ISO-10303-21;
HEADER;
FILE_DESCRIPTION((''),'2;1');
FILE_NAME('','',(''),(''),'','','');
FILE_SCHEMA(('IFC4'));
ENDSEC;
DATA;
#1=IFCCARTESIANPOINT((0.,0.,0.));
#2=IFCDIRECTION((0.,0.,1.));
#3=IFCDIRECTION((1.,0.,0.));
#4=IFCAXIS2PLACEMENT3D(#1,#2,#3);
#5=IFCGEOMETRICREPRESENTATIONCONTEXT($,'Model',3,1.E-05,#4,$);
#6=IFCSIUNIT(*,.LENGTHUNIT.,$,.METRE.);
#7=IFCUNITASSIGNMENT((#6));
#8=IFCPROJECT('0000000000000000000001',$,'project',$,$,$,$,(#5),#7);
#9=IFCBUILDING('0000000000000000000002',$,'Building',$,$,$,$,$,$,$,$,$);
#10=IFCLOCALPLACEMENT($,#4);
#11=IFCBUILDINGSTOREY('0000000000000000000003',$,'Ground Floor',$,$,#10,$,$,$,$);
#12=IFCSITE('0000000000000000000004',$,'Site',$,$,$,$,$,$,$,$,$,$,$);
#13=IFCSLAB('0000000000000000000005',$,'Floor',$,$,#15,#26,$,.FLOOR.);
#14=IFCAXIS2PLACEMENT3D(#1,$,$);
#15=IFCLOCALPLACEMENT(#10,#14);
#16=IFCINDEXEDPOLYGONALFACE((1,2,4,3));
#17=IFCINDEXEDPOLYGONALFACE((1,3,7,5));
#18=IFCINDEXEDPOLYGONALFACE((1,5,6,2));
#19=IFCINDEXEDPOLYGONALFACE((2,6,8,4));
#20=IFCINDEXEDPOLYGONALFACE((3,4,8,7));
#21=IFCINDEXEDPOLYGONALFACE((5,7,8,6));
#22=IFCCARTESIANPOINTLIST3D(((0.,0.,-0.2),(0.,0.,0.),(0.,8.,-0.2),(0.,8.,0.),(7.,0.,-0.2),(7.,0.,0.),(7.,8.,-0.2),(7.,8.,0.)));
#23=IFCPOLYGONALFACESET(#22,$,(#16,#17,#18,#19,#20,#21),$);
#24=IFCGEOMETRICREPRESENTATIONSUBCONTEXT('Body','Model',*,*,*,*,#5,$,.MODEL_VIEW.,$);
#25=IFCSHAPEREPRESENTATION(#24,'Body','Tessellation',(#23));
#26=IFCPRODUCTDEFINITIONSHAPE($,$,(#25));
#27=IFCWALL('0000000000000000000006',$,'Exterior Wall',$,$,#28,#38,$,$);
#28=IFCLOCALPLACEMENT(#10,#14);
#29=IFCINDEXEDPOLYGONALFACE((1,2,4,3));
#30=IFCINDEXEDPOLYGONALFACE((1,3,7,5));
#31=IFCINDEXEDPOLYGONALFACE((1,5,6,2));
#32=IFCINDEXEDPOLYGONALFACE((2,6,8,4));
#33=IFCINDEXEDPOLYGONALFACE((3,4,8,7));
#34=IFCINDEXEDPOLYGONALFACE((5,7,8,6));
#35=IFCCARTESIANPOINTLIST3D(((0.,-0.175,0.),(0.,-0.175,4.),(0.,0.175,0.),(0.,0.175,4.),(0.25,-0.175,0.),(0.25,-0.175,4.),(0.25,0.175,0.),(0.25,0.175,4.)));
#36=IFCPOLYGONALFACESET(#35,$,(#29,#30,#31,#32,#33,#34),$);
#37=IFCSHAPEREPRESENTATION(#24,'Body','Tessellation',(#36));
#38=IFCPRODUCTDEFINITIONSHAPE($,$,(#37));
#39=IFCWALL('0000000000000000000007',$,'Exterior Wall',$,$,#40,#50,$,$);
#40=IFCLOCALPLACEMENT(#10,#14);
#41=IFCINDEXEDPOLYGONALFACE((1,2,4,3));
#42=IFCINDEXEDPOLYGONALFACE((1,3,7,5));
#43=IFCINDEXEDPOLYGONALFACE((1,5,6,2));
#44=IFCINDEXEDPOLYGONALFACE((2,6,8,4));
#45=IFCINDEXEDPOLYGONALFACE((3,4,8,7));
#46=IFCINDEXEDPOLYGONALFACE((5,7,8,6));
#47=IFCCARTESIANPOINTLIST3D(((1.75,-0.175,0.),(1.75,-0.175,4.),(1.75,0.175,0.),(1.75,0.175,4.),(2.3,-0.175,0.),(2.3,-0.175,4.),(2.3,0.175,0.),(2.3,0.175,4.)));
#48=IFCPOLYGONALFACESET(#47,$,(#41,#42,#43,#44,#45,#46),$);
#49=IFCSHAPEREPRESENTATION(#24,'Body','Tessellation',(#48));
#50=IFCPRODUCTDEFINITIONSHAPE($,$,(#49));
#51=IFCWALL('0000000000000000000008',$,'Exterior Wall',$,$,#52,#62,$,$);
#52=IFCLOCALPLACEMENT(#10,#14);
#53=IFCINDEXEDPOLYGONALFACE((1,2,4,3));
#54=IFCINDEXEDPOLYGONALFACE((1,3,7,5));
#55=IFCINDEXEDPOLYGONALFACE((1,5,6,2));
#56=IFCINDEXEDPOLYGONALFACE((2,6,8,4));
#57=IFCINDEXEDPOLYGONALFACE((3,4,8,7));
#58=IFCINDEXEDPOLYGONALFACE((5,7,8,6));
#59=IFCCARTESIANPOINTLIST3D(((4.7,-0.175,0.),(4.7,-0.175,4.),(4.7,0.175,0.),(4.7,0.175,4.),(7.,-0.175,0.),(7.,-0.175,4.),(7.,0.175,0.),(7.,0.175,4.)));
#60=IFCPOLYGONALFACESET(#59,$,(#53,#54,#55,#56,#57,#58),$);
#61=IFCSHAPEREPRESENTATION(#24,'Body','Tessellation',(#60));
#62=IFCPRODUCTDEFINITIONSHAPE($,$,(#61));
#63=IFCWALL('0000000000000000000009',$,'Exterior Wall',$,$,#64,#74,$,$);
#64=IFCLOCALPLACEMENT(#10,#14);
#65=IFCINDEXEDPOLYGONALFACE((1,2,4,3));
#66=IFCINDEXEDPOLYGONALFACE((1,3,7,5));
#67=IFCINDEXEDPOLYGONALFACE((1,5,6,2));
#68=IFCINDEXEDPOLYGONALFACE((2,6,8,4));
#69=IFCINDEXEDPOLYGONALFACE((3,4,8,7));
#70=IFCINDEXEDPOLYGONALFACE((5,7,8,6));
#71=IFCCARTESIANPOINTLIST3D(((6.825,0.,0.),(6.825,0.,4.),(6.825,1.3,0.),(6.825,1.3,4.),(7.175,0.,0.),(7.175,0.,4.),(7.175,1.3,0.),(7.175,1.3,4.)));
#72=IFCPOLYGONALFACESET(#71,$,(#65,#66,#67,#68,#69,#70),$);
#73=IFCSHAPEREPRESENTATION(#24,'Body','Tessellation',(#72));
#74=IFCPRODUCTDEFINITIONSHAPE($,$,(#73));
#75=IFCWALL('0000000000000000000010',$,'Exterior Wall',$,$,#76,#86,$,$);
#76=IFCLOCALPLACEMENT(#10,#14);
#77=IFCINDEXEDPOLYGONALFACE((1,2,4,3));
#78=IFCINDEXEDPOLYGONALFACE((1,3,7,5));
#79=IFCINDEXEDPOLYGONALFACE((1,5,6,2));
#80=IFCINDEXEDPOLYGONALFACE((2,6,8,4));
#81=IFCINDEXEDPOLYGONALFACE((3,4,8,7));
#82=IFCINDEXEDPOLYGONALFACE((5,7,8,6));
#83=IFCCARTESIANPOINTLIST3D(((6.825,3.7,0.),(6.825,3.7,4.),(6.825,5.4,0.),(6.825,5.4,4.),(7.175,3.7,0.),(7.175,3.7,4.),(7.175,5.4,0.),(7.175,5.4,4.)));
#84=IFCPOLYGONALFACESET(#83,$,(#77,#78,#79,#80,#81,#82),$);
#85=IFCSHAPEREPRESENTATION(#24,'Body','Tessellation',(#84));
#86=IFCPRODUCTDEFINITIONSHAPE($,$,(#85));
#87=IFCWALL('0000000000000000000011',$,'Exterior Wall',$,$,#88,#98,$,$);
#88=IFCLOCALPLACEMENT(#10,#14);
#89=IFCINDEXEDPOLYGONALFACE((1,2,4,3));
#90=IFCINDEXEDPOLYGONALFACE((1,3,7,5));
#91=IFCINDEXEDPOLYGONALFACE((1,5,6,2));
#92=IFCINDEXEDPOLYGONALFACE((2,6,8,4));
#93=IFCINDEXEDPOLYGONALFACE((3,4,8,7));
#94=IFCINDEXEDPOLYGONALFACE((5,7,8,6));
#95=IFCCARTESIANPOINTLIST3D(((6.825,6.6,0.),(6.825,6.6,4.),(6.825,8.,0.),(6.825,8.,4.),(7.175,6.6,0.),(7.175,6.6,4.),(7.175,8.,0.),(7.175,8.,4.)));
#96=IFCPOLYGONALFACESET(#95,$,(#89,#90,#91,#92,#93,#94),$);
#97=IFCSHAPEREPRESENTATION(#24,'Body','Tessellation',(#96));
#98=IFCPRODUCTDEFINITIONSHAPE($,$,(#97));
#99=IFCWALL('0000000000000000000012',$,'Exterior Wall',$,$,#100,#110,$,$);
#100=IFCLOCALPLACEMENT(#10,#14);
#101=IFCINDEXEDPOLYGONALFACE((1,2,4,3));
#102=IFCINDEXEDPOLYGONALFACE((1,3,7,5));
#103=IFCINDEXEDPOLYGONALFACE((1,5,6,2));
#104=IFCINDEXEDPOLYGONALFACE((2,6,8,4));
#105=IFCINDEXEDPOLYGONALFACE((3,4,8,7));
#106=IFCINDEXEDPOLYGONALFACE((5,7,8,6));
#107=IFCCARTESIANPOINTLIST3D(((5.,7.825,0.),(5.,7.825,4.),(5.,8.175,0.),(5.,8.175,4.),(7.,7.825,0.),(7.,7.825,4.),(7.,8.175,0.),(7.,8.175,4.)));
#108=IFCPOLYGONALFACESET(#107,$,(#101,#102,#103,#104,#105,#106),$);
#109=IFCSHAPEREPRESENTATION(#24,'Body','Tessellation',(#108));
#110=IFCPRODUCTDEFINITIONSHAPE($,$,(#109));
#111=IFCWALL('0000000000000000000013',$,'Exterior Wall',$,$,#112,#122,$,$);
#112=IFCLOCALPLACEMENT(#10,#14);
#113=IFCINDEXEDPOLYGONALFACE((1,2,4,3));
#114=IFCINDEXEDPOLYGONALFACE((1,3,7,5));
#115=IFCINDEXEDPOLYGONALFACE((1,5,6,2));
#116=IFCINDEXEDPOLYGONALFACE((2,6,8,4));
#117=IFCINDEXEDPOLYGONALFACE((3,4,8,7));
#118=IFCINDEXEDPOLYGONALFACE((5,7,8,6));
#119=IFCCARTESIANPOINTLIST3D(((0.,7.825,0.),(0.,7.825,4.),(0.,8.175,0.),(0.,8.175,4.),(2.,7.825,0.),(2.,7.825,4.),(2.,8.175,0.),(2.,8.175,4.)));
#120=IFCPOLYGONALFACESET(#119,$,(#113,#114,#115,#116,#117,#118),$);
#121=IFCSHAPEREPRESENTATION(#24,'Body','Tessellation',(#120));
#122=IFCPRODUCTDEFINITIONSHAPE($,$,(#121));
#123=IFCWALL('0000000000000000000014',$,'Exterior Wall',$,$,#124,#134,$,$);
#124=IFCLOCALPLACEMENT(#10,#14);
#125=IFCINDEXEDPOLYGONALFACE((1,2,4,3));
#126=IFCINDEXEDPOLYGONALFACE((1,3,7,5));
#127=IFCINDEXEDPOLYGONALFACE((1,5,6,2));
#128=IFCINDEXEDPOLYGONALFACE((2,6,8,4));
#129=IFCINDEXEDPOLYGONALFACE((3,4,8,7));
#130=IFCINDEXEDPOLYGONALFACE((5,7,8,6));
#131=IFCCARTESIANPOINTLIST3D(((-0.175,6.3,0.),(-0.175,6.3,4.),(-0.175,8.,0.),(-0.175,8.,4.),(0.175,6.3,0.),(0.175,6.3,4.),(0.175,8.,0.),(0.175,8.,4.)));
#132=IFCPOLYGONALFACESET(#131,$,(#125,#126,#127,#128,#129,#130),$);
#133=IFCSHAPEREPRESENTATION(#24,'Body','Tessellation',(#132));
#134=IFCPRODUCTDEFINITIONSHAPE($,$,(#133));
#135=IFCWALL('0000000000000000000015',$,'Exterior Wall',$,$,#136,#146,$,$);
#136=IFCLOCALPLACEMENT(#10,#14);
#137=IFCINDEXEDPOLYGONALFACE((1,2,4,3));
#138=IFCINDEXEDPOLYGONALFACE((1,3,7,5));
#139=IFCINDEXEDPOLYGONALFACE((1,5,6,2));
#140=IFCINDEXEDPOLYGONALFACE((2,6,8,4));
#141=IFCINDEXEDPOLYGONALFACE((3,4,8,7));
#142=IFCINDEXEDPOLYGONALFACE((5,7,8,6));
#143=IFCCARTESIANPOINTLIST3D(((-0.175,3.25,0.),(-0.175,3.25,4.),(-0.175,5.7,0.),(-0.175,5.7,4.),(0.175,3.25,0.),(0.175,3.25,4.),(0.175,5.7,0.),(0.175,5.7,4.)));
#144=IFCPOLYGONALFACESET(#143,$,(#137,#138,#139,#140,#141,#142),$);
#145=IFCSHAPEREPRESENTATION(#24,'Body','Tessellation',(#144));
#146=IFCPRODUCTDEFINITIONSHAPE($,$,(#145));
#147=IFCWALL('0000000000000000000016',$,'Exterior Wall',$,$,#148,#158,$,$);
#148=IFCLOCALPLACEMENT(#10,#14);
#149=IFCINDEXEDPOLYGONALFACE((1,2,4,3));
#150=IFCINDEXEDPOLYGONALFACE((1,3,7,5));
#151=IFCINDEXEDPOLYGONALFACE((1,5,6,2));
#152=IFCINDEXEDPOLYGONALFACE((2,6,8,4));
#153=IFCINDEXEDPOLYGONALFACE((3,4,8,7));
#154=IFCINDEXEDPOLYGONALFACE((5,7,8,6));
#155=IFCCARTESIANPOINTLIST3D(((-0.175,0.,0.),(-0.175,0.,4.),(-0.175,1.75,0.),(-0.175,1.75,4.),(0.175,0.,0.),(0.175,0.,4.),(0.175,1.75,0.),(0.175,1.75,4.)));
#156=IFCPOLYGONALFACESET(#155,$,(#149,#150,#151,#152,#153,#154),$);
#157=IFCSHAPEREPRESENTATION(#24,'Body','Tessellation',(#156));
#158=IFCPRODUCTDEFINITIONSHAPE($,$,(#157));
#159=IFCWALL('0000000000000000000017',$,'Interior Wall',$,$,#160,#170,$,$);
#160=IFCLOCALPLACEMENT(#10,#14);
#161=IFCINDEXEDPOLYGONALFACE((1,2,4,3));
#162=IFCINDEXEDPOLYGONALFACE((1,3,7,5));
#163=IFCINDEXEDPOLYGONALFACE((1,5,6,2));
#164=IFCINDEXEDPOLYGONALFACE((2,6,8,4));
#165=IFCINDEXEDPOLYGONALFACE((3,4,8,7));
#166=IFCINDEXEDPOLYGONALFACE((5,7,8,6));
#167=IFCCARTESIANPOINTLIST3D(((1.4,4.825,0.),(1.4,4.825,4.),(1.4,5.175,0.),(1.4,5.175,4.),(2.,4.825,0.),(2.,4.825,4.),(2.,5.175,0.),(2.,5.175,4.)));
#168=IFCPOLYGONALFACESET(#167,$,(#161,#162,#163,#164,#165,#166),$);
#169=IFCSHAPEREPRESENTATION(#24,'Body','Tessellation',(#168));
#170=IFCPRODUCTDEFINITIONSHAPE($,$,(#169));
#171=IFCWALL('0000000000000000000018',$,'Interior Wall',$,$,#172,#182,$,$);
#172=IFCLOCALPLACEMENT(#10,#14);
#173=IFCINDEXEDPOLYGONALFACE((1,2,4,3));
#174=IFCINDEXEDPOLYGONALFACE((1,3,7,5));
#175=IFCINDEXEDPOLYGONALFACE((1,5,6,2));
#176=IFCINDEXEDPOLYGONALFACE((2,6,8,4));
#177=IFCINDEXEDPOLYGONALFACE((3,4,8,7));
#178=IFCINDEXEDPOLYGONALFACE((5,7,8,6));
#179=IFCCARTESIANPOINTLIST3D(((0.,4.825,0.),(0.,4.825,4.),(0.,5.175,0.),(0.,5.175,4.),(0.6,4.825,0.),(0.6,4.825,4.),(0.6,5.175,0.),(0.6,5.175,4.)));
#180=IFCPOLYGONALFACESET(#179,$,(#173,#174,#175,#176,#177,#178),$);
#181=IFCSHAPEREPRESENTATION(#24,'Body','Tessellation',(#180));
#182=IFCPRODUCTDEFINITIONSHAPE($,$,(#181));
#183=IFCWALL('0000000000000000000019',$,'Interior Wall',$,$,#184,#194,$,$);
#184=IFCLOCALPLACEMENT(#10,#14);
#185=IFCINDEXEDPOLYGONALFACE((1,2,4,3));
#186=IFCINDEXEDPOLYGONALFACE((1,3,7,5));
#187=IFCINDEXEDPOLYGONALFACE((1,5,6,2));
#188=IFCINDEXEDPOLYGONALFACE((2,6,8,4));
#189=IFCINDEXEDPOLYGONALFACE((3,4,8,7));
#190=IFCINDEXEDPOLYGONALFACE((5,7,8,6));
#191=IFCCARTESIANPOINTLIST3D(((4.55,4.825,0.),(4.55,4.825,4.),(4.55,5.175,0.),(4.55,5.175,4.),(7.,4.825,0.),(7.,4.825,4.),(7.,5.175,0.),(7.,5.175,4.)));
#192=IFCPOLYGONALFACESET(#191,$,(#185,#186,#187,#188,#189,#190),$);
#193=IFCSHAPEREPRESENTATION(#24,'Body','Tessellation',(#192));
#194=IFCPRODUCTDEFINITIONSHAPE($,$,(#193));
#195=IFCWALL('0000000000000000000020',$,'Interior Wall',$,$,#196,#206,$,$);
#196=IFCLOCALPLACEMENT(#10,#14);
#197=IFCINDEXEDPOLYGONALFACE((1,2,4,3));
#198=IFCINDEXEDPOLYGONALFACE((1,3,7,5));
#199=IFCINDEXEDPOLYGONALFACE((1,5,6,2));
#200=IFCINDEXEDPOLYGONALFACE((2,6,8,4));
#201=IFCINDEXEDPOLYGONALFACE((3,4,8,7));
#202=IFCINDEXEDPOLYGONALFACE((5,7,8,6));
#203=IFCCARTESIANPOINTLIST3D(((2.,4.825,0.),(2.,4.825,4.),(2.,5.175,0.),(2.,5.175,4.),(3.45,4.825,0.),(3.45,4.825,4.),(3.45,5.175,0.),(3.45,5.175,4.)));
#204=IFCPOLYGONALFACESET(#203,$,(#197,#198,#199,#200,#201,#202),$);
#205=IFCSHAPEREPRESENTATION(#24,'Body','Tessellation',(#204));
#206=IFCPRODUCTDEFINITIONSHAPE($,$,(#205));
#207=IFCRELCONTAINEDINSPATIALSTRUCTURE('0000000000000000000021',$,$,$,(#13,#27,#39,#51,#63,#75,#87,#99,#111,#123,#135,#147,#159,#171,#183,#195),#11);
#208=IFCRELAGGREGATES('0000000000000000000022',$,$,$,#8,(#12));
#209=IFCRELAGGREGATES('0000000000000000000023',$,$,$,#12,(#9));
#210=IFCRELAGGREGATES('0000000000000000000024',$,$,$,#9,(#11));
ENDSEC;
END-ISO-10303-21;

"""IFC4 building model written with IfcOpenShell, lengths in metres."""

from ifc_helpers import new_model, si_unit, frame, origin_with_axes, place, context, subcontext, project, spatial, indexed_curve, outline, extrude, element, save


model = new_model("IFC4")

# Units and contexts
model_context = context("Model", 3, precision=1e-05, world=origin_with_axes())
body_context = subcontext(model_context, "Body", "Model", "MODEL_VIEW")
ifc_project = project(units=[si_unit("LENGTHUNIT", "METRE")], contexts=[model_context])

# Site, building, storey
site = spatial("IfcSite", under=ifc_project, Name="Site")
building = spatial("IfcBuilding", under=site, Name="Building")
storey_placement = place(None, origin_with_axes())
storey = spatial("IfcBuildingStorey", under=building, at=storey_placement, Name="Ground Floor")

# Slab
slab_placement = place(storey_placement, frame((0.0, 0.0, -0.2), z_axis=(0.0, 0.0, 1.0), x_axis=(1.0, 0.0, 0.0)))
element("IfcSlab", 1, at=slab_placement, inside=storey, Name="Floor", PredefinedType="FLOOR", context=body_context, shape_type="SweptSolid", body=[
    extrude(outline(indexed_curve([(0.0, 0.0), (7.0, 0.0), (7.0, 8.0), (0.0, 8.0)])), None, (0.0, 0.0, 1.0), 0.2),
])

# Walls
wall_1_placement = place(storey_placement, origin_with_axes())
element("IfcWall", 2, at=wall_1_placement, inside=storey, Name="Exterior Wall", context=body_context, shape_type="SweptSolid", body=[
    extrude(outline(indexed_curve([(0.0, 0.0), (0.0, 0.35), (0.25, 0.35), (0.25, 0.0), (0.0, 0.0)], self_intersect=False)), frame((0.0, -0.175, 0.0), z_axis=(0.0, 0.0, 1.0), x_axis=(1.0, 0.0, 0.0)), (0.0, 0.0, 1.0), 4.0),
])
wall_2_placement = place(storey_placement, frame((1.75, 0.0, 0.0), z_axis=(0.0, 0.0, 1.0), x_axis=(1.0, 0.0, 0.0)))
element("IfcWall", 3, at=wall_2_placement, inside=storey, Name="Exterior Wall", context=body_context, shape_type="SweptSolid", body=[
    extrude(outline(indexed_curve([(0.0, 0.0), (0.0, 0.35), (0.55, 0.35), (0.55, 0.0), (0.0, 0.0)], self_intersect=False)), frame((0.0, -0.175, 0.0), z_axis=(0.0, 0.0, 1.0), x_axis=(1.0, 0.0, 0.0)), (0.0, 0.0, 1.0), 4.0),
])
wall_3_placement = place(storey_placement, frame((4.7, 0.0, 0.0), z_axis=(0.0, 0.0, 1.0), x_axis=(1.0, 0.0, 0.0)))
element("IfcWall", 4, at=wall_3_placement, inside=storey, Name="Exterior Wall", context=body_context, shape_type="SweptSolid", body=[
    extrude(outline(indexed_curve([(0.0, 0.0), (0.0, 0.35), (2.3, 0.35), (2.3, 0.0), (0.0, 0.0)], self_intersect=False)), frame((0.0, -0.175, 0.0), z_axis=(0.0, 0.0, 1.0), x_axis=(1.0, 0.0, 0.0)), (0.0, 0.0, 1.0), 4.0),
])
wall_4_placement = place(storey_placement, frame((7.0, 0.0, 0.0), z_axis=(0.0, 0.0, 1.0), x_axis=(0.0, 1.0, 0.0)))
element("IfcWall", 5, at=wall_4_placement, inside=storey, Name="Exterior Wall", context=body_context, shape_type="SweptSolid", body=[
    extrude(outline(indexed_curve([(0.0, 0.0), (0.0, 0.35), (1.3, 0.35), (1.3, 0.0), (0.0, 0.0)], self_intersect=False)), frame((0.0, -0.175, 0.0), z_axis=(0.0, 0.0, 1.0), x_axis=(1.0, 0.0, 0.0)), (0.0, 0.0, 1.0), 4.0),
])
wall_5_placement = place(storey_placement, frame((7.0, 3.7, 0.0), z_axis=(0.0, 0.0, 1.0), x_axis=(0.0, 1.0, 0.0)))
element("IfcWall", 6, at=wall_5_placement, inside=storey, Name="Exterior Wall", context=body_context, shape_type="SweptSolid", body=[
    extrude(outline(indexed_curve([(0.0, 0.0), (0.0, 0.35), (1.7, 0.35), (1.7, 0.0), (0.0, 0.0)], self_intersect=False)), frame((0.0, -0.175, 0.0), z_axis=(0.0, 0.0, 1.0), x_axis=(1.0, 0.0, 0.0)), (0.0, 0.0, 1.0), 4.0),
])
wall_6_placement = place(storey_placement, frame((7.0, 6.6, 0.0), z_axis=(0.0, 0.0, 1.0), x_axis=(0.0, 1.0, 0.0)))
element("IfcWall", 7, at=wall_6_placement, inside=storey, Name="Exterior Wall", context=body_context, shape_type="SweptSolid", body=[
    extrude(outline(indexed_curve([(0.0, 0.0), (0.0, 0.35), (1.4, 0.35), (1.4, 0.0), (0.0, 0.0)], self_intersect=False)), frame((0.0, -0.175, 0.0), z_axis=(0.0, 0.0, 1.0), x_axis=(1.0, 0.0, 0.0)), (0.0, 0.0, 1.0), 4.0),
])
for number, where, z_axis, x_axis, name in (
    (8, (7.0, 8.0, 0.0), (0.0, 0.0, 1.0), (-1.0, 0.0, 0.0), "Exterior Wall"),
    (9, (2.0, 8.0, 0.0), (0.0, 0.0, 1.0), (-1.0, 0.0, 0.0), "Exterior Wall"),
):
    element("IfcWall", number, at=place(storey_placement, frame(where, z_axis=z_axis, x_axis=x_axis)), inside=storey, Name=name, context=body_context, shape_type="SweptSolid", body=[
        extrude(outline(indexed_curve([(0.0, 0.0), (0.0, 0.35), (2.0, 0.35), (2.0, 0.0), (0.0, 0.0)], self_intersect=False)), frame((0.0, -0.175, 0.0), z_axis=(0.0, 0.0, 1.0), x_axis=(1.0, 0.0, 0.0)), (0.0, 0.0, 1.0), 4.0),
    ])
wall_7_placement = place(storey_placement, frame((0.0, 8.0, 0.0), z_axis=(0.0, 0.0, 1.0), x_axis=(0.0, -1.0, 0.0)))
element("IfcWall", 10, at=wall_7_placement, inside=storey, Name="Exterior Wall", context=body_context, shape_type="SweptSolid", body=[
    extrude(outline(indexed_curve([(0.0, 0.0), (0.0, 0.35), (1.7, 0.35), (1.7, 0.0), (0.0, 0.0)], self_intersect=False)), frame((0.0, -0.175, 0.0), z_axis=(0.0, 0.0, 1.0), x_axis=(1.0, 0.0, 0.0)), (0.0, 0.0, 1.0), 4.0),
])
wall_8_placement = place(storey_placement, frame((0.0, 5.7, 0.0), z_axis=(0.0, 0.0, 1.0), x_axis=(0.0, -1.0, 0.0)))
element("IfcWall", 11, at=wall_8_placement, inside=storey, Name="Exterior Wall", context=body_context, shape_type="SweptSolid", body=[
    extrude(outline(indexed_curve([(0.0, 0.0), (0.0, 0.35), (2.45, 0.35), (2.45, 0.0), (0.0, 0.0)], self_intersect=False)), frame((0.0, -0.175, 0.0), z_axis=(0.0, 0.0, 1.0), x_axis=(1.0, 0.0, 0.0)), (0.0, 0.0, 1.0), 4.0),
])
wall_9_placement = place(storey_placement, frame((0.0, 1.75, 0.0), z_axis=(0.0, 0.0, 1.0), x_axis=(0.0, -1.0, 0.0)))
element("IfcWall", 12, at=wall_9_placement, inside=storey, Name="Exterior Wall", context=body_context, shape_type="SweptSolid", body=[
    extrude(outline(indexed_curve([(0.0, 0.0), (0.0, 0.35), (1.75, 0.35), (1.75, 0.0), (0.0, 0.0)], self_intersect=False)), frame((0.0, -0.175, 0.0), z_axis=(0.0, 0.0, 1.0), x_axis=(1.0, 0.0, 0.0)), (0.0, 0.0, 1.0), 4.0),
])
for number, where, z_axis, x_axis, name in (
    (13, (2.0, 5.0, 0.0), (0.0, 0.0, 1.0), (-1.0, 0.0, 0.0), "Interior Wall"),
    (14, (0.6, 5.0, 0.0), (0.0, 0.0, 1.0), (-1.0, 0.0, 0.0), "Interior Wall"),
):
    element("IfcWall", number, at=place(storey_placement, frame(where, z_axis=z_axis, x_axis=x_axis)), inside=storey, Name=name, context=body_context, shape_type="SweptSolid", body=[
        extrude(outline(indexed_curve([(0.0, 0.0), (0.0, 0.35), (0.6, 0.35), (0.6, 0.0), (0.0, 0.0)], self_intersect=False)), frame((0.0, -0.175, 0.0), z_axis=(0.0, 0.0, 1.0), x_axis=(1.0, 0.0, 0.0)), (0.0, 0.0, 1.0), 4.0),
    ])
wall_10_placement = place(storey_placement, frame((7.0, 5.0, 0.0), z_axis=(0.0, 0.0, 1.0), x_axis=(-1.0, 0.0, 0.0)))
element("IfcWall", 15, at=wall_10_placement, inside=storey, Name="Interior Wall", context=body_context, shape_type="SweptSolid", body=[
    extrude(outline(indexed_curve([(0.0, 0.0), (0.0, 0.35), (2.45, 0.35), (2.45, 0.0), (0.0, 0.0)], self_intersect=False)), frame((0.0, -0.175, 0.0), z_axis=(0.0, 0.0, 1.0), x_axis=(1.0, 0.0, 0.0)), (0.0, 0.0, 1.0), 4.0),
])
wall_11_placement = place(storey_placement, frame((3.45, 5.0, 0.0), z_axis=(0.0, 0.0, 1.0), x_axis=(-1.0, 0.0, 0.0)))
element("IfcWall", 16, at=wall_11_placement, inside=storey, Name="Interior Wall", context=body_context, shape_type="SweptSolid", body=[
    extrude(outline(indexed_curve([(0.0, 0.0), (0.0, 0.35), (1.45, 0.35), (1.45, 0.0), (0.0, 0.0)], self_intersect=False)), frame((0.0, -0.175, 0.0), z_axis=(0.0, 0.0, 1.0), x_axis=(1.0, 0.0, 0.0)), (0.0, 0.0, 1.0), 4.0),
])

save(model, "model.ifc")
